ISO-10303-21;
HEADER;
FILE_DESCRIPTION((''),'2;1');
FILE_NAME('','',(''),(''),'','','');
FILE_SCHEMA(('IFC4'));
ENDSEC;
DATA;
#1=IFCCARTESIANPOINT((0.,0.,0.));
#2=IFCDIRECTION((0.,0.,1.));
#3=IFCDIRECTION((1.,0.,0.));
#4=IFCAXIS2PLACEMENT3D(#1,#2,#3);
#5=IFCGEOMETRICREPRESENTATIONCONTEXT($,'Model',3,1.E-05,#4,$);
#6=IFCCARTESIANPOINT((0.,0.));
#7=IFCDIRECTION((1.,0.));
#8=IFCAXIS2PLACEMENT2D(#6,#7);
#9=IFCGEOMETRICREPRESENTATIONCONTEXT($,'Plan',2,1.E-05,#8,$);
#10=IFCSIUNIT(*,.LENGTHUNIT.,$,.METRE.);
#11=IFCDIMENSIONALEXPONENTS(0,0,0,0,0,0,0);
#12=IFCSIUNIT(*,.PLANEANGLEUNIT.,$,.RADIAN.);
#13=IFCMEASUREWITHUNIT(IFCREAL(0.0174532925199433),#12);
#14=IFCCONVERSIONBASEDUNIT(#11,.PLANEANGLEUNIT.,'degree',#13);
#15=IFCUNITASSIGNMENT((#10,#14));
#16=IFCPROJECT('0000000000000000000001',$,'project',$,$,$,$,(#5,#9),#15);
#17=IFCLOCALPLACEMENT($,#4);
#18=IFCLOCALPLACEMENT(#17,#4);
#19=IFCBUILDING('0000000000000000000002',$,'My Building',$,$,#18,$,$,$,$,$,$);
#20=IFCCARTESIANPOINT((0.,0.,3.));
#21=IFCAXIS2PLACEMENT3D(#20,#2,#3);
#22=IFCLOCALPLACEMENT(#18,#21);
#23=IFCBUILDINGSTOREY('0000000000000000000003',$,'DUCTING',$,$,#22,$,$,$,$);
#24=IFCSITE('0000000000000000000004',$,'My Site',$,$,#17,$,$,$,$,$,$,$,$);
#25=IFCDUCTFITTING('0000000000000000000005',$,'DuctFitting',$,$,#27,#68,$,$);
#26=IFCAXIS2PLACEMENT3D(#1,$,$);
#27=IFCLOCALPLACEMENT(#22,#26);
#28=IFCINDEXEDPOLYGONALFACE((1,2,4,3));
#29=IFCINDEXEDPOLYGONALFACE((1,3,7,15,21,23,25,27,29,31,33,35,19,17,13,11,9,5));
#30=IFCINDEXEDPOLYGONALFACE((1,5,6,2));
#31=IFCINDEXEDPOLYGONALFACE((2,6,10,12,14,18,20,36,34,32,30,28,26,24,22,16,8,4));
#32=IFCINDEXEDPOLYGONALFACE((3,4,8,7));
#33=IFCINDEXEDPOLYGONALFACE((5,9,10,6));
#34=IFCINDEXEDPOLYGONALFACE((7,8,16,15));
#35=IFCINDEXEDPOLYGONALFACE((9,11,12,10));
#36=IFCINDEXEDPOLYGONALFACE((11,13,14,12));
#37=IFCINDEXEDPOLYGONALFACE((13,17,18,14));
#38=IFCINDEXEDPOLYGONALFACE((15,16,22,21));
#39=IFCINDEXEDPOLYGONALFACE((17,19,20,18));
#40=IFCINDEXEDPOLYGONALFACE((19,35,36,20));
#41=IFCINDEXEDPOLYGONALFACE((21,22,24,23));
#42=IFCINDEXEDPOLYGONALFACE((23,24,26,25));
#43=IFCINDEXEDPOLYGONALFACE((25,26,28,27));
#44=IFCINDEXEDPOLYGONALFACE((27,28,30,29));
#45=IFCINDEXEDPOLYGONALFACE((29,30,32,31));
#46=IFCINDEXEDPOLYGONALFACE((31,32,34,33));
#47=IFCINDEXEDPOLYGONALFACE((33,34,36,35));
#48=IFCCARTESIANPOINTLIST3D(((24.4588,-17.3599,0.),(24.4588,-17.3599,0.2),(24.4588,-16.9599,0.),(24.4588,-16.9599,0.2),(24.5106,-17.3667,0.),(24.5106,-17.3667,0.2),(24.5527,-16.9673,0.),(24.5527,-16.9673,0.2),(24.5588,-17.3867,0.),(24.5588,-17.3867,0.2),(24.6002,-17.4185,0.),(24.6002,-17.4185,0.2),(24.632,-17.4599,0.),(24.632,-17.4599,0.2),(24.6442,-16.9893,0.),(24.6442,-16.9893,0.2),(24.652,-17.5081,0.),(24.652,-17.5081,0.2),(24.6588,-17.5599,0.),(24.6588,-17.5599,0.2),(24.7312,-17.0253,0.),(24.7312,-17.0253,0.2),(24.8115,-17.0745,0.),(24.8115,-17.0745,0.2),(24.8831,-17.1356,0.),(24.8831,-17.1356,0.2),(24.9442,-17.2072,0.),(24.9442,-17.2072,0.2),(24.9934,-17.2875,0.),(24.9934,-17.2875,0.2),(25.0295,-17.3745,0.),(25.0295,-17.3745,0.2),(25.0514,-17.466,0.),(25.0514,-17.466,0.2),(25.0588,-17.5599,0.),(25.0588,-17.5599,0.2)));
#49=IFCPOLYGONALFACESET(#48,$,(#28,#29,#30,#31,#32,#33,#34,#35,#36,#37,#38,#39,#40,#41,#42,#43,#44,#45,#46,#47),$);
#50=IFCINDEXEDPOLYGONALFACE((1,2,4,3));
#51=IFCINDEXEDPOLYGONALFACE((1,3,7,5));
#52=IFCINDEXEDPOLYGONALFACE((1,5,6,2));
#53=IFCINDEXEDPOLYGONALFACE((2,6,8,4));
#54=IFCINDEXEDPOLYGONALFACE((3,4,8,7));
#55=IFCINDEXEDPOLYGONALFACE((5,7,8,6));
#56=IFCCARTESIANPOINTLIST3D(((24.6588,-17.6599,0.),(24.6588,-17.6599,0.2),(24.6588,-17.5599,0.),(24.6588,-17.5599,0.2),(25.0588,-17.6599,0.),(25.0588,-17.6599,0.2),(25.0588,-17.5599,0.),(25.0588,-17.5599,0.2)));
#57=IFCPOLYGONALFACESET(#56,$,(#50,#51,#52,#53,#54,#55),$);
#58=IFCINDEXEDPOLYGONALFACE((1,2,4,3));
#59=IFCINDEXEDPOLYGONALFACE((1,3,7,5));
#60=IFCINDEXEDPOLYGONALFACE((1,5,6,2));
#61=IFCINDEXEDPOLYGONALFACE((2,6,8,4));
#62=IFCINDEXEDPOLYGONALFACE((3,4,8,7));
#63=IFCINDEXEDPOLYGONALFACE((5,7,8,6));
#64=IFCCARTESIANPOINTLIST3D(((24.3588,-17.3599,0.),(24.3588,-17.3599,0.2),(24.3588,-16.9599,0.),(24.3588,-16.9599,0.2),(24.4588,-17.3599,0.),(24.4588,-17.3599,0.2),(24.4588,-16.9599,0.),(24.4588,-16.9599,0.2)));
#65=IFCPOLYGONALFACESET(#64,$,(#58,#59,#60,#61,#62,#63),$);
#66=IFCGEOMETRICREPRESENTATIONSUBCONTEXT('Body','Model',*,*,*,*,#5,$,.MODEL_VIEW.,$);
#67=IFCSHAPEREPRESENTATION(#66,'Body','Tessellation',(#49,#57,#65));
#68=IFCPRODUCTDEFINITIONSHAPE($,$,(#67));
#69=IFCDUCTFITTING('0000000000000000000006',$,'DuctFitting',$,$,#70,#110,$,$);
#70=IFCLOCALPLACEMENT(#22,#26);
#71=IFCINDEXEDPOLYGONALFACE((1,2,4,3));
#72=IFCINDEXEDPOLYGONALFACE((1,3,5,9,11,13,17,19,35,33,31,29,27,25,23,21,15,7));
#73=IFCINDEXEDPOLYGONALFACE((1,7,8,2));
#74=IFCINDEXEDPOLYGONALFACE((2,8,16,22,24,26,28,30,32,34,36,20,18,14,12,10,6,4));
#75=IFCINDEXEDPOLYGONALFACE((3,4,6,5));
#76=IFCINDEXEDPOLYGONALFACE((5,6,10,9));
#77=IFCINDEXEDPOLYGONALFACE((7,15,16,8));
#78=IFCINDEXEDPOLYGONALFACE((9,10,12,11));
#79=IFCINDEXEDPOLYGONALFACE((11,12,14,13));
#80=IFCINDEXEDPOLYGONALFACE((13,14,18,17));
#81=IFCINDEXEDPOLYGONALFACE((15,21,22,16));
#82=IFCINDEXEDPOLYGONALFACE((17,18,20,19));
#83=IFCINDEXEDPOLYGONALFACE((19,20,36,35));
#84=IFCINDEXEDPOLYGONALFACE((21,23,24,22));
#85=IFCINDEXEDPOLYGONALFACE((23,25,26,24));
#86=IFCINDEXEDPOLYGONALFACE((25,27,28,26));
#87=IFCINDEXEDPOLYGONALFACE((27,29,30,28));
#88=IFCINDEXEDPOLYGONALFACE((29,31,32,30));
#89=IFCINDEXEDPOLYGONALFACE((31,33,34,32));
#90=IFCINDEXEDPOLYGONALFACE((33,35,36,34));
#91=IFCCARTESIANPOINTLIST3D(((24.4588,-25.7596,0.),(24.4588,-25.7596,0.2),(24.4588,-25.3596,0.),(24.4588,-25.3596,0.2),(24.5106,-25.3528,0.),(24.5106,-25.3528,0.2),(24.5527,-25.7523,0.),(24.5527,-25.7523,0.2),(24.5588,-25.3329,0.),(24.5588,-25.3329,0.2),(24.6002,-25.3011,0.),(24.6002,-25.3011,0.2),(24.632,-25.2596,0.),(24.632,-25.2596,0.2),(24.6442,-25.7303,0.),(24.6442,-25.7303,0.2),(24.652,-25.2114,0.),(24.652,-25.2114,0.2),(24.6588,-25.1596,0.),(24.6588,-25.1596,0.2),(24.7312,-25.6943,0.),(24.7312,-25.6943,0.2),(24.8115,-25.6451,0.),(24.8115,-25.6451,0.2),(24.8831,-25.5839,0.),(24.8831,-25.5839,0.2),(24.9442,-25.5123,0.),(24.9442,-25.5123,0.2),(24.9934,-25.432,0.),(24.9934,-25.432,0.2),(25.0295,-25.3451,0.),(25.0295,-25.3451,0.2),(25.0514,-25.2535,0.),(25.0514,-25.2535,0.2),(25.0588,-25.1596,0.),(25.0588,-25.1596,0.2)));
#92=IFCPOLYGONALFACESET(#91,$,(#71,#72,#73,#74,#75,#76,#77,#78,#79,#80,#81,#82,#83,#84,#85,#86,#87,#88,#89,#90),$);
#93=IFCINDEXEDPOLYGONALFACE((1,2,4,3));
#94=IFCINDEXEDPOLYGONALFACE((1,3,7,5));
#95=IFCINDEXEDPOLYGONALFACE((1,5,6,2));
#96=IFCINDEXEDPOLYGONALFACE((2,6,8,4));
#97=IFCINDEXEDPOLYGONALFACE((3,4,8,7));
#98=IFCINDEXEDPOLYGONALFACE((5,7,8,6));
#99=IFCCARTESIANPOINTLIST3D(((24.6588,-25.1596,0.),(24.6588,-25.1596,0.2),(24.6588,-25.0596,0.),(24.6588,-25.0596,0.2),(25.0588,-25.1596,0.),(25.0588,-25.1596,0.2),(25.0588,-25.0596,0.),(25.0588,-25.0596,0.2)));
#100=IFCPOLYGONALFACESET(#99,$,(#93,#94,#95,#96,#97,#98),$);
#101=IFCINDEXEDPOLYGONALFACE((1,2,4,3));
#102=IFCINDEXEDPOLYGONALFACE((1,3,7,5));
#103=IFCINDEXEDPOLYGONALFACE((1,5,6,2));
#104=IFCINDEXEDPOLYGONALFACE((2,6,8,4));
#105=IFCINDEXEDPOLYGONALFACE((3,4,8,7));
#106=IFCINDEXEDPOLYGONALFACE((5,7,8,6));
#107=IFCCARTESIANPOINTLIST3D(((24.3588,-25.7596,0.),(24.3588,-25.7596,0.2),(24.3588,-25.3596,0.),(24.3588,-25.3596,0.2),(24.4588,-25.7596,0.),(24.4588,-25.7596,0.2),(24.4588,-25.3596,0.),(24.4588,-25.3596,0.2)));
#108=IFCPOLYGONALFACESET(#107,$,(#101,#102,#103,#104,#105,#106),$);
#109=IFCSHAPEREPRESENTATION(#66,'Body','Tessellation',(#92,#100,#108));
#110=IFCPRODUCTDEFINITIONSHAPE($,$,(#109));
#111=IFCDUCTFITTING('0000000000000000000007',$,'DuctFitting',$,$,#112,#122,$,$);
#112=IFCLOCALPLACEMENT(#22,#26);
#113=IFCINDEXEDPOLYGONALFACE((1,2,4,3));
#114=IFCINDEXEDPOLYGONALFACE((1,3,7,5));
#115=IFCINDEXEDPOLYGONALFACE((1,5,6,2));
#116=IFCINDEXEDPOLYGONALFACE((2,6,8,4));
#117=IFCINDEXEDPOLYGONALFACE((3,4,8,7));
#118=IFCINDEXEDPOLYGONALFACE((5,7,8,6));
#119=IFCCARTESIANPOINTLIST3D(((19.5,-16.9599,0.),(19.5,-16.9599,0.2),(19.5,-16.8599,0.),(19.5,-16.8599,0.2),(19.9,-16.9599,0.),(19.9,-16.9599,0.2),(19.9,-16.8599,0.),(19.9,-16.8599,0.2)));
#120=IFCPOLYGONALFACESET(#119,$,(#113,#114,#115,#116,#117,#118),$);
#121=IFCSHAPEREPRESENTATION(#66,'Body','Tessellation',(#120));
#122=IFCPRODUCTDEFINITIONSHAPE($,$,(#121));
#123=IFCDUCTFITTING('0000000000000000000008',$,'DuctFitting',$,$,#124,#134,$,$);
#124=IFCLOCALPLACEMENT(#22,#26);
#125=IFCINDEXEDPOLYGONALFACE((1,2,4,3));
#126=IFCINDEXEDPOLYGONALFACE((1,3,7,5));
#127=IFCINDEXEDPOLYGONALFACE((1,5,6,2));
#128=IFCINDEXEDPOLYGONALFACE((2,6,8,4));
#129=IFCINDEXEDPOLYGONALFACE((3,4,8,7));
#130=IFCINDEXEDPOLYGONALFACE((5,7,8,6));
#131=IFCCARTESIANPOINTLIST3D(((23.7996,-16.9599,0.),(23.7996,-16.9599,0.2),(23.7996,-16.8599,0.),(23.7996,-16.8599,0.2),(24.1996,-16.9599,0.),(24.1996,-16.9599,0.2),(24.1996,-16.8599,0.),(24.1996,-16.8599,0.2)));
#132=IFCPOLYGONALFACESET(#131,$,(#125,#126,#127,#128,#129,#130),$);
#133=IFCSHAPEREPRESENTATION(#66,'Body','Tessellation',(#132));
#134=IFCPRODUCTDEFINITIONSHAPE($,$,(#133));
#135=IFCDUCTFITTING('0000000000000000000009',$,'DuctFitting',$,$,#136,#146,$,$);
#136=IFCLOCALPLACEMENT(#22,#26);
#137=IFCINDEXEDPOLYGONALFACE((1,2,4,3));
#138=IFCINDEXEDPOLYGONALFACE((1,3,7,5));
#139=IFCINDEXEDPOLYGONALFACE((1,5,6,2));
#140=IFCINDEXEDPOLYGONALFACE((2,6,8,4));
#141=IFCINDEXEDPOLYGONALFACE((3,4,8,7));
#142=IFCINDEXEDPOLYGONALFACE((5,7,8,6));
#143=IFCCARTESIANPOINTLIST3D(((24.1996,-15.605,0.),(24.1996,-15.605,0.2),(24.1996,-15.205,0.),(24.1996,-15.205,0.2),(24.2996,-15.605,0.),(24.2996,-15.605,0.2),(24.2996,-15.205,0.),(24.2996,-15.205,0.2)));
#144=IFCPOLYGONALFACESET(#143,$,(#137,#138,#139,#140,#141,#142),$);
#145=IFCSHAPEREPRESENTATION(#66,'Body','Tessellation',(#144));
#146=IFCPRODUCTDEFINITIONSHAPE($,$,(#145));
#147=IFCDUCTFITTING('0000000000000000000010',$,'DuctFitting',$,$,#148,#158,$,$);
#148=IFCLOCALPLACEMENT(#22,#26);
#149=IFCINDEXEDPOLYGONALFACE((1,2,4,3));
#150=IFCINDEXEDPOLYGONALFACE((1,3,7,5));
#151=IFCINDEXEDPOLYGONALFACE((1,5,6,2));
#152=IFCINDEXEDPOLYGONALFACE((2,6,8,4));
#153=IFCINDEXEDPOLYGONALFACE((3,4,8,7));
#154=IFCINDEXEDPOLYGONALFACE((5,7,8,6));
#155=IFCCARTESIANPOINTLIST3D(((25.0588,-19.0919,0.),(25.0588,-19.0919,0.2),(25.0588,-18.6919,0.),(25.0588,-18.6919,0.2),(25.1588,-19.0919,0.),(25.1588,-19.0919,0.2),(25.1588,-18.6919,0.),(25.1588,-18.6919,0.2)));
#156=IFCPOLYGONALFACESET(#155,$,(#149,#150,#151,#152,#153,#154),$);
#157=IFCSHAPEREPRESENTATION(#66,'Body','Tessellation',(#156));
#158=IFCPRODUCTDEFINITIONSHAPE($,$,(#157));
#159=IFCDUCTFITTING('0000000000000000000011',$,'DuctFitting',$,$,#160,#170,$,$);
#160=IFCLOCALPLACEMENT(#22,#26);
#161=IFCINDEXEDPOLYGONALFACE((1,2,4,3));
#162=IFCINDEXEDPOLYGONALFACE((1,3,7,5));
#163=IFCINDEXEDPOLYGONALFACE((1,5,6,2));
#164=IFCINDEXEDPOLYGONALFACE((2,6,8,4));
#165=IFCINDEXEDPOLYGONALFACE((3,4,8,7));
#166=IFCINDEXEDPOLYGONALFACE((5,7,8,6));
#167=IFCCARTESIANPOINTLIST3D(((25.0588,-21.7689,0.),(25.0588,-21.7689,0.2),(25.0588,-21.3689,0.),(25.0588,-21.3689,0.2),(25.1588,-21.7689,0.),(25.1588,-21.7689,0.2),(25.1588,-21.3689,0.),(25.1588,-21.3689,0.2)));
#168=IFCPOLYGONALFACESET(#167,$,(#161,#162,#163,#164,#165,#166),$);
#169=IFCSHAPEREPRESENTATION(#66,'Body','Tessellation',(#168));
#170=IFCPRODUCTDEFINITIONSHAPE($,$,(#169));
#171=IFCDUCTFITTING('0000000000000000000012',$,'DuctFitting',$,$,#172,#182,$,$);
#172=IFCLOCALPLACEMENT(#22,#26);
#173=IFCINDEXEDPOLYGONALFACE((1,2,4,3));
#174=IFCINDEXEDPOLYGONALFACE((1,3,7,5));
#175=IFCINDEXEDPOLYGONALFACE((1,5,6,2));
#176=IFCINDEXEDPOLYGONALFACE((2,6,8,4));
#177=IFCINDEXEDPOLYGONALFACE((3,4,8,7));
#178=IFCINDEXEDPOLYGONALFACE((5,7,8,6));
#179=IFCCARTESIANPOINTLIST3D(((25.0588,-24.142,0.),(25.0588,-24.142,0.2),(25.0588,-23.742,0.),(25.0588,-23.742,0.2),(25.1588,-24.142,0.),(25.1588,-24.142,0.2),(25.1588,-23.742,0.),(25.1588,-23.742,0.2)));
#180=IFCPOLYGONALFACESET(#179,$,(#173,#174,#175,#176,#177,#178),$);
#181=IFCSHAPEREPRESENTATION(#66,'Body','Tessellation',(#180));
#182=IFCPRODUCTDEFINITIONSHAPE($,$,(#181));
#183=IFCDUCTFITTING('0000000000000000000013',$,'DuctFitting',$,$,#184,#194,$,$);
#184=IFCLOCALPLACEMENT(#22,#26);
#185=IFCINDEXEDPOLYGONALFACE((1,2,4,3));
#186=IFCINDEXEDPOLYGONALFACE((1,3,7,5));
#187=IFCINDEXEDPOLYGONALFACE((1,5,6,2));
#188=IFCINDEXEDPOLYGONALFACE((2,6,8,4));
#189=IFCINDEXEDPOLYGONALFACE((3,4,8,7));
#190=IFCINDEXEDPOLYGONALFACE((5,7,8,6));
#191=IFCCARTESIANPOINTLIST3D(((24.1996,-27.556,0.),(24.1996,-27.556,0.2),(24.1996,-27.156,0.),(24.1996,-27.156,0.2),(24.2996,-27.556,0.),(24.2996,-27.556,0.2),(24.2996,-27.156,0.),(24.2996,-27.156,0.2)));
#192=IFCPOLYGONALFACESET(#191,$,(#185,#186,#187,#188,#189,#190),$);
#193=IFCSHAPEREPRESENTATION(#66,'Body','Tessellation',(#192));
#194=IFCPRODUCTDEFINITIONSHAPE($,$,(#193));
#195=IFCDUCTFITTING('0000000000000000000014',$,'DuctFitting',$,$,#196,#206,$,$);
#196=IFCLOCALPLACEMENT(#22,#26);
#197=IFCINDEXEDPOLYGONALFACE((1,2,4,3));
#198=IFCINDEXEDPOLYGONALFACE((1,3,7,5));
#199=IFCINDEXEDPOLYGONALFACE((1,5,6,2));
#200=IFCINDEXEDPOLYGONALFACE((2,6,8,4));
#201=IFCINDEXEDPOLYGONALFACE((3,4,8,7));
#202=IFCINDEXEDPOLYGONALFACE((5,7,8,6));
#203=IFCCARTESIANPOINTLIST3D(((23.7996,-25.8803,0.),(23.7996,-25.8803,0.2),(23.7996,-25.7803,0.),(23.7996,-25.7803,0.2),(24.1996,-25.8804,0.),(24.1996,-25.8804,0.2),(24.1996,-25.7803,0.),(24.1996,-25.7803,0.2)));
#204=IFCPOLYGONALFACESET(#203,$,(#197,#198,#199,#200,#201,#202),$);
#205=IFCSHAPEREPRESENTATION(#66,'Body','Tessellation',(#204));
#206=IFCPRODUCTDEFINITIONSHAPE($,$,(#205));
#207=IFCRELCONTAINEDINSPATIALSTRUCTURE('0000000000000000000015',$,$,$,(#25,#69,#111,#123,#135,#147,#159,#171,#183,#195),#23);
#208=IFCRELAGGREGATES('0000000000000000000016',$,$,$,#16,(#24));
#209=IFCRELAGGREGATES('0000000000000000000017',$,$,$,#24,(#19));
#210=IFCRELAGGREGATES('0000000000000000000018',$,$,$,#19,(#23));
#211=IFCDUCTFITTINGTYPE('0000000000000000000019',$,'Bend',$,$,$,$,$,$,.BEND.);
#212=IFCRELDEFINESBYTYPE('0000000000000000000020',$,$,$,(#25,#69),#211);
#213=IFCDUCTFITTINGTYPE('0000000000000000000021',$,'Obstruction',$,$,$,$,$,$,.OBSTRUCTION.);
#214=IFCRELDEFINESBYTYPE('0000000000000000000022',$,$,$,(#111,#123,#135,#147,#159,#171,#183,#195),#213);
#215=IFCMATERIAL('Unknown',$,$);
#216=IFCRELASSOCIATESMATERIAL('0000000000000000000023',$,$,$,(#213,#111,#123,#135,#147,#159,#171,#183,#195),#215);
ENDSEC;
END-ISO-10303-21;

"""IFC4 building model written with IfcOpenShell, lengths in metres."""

from ifc_helpers import new_model, entity, si_unit, converted_unit, frame, origin_with_axes, origin_2d_with_axis, place, context, subcontext, project, spatial, line, arc, indexed_curve, rectangle, outline, extrude, source, transform, mapped, material, material_profile, profile_set, profile_usage, type_object, type_shapes, element, save


model = new_model("IFC4")

# Units and contexts
model_context = context("Model", 3, precision=1e-05, world=origin_with_axes())
plan_context = context("Plan", 2, precision=1e-05, world=origin_2d_with_axis())
body_context = subcontext(model_context, "Body", "Model", "MODEL_VIEW")
ifc_project = project(units=[si_unit("LENGTHUNIT", "METRE"), converted_unit("PLANEANGLEUNIT", "degree", entity("IfcReal", 0.0174532925199433), si_unit("PLANEANGLEUNIT", "RADIAN"), dimensions=[0, 0, 0, 0, 0, 0, 0])], contexts=[model_context, plan_context])

# Site, building, storey
site_placement = place(None, origin_with_axes())
site = spatial("IfcSite", under=ifc_project, at=site_placement, Name="My Site")
building_placement = place(site_placement, origin_with_axes())
building = spatial("IfcBuilding", under=site, at=building_placement, Name="My Building")
storey_placement = place(building_placement, frame((0.0, 0.0, 3.0), z_axis=(0.0, 0.0, 1.0), x_axis=(1.0, 0.0, 0.0)))
storey = spatial("IfcBuildingStorey", under=building, at=storey_placement, Name="DUCTING")

# Shared definitions
ifc_material = material(Name="Unknown")

# Duct fittings
duct_fitting_type_1 = type_object("IfcDuctFittingType", Name="Bend", PredefinedType="BEND")
shared_shape = source(origin_with_axes(), body_context, "Body", "SweptSolid", [
    extrude(outline(indexed_curve([(0.2, 0.0), (0.2586, 0.1414), (0.4, 0.2), (0.4, 0.6), (-0.0243, 0.4243), (-0.2, 0.0)], segments=[arc(1, 2, 3), line(3, 4), arc(4, 5, 6), line(6, 1)])), frame((0.0, -0.1, 0.1), z_axis=(0.0, -1.0, 0.0), x_axis=(1.0, 0.0, 0.0)), (0.0, 0.0, -1.0), 0.2),
    extrude(rectangle(XDim=0.4, YDim=0.2), origin_with_axes(), (0.0, 0.0, 1.0), 0.1),
    extrude(rectangle(XDim=0.4, YDim=0.2), frame((0.4, 0.0, 0.5), z_axis=(1.0, 0.0, 0.0), x_axis=(0.0, 0.0, 1.0)), (0.0, 0.0, 1.0), 0.1),
])
type_shapes(duct_fitting_type_1, [shared_shape])
for number, where, z_axis, x_axis, name in (
    (1, (24.8588, -17.6599, 0.1), (0.0, 1.0, 0.0), (-1.0, 0.0, 0.0), "DuctFitting"),
    (2, (24.8588, -25.0596, 0.1), (0.0, -1.0, 0.0), (-1.0, 0.0, 0.0), "DuctFitting"),
):
    element("IfcDuctFitting", number, at=place(storey_placement, frame(where, z_axis=z_axis, x_axis=x_axis)), inside=storey, type_object=duct_fitting_type_1, Name=name, context=body_context, shape_type="MappedRepresentation", body=[
        mapped(shared_shape, transform((0.0, 0.0, 0.0), x_axis=(1.0, 0.0, 0.0), y_axis=(0.0, 1.0, 0.0), z_axis=(0.0, 0.0, 1.0), scale=1.0)),
    ])
ifc_material_profile_1 = material_profile(ifc_material, rectangle(XDim=0.4, YDim=0.2))
ifc_profile_set_1 = profile_set([ifc_material_profile_1])
ifc_profile_usage_1 = profile_usage(ifc_profile_set_1, cardinal=5)
duct_fitting_type_2 = type_object("IfcDuctFittingType", Name="Obstruction", PredefinedType="OBSTRUCTION", material=ifc_profile_set_1)
duct_fitting_1_placement = place(storey_placement, frame((19.7, -16.8599, 0.1), z_axis=(0.0, -1.0, 0.0), x_axis=(1.0, 0.0, 0.0)))
element("IfcDuctFitting", 3, at=duct_fitting_1_placement, inside=storey, type_object=duct_fitting_type_2, material=ifc_profile_usage_1, Name="DuctFitting", context=body_context, shape_type="SweptSolid", body=[
    extrude(rectangle(XDim=0.4, YDim=0.2), origin_with_axes(), (0.0, 0.0, 1.0), 0.1),
])
ifc_profile_usage_2 = profile_usage(ifc_profile_set_1, cardinal=5)
duct_fitting_2_placement = place(storey_placement, frame((23.9996, -16.8599, 0.1), z_axis=(0.0, -1.0, 0.0), x_axis=(1.0, 0.0, 0.0)))
element("IfcDuctFitting", 4, at=duct_fitting_2_placement, inside=storey, type_object=duct_fitting_type_2, material=ifc_profile_usage_2, Name="DuctFitting", context=body_context, shape_type="SweptSolid", body=[
    extrude(rectangle(XDim=0.4, YDim=0.2), origin_with_axes(), (0.0, 0.0, 1.0), 0.1),
])
ifc_profile_usage_3 = profile_usage(ifc_profile_set_1, cardinal=5)
duct_fitting_3_placement = place(storey_placement, frame((24.2996, -15.405, 0.1), z_axis=(-1.0, 0.0, 0.0), x_axis=(0.0, -1.0, 0.0)))
element("IfcDuctFitting", 5, at=duct_fitting_3_placement, inside=storey, type_object=duct_fitting_type_2, material=ifc_profile_usage_3, Name="DuctFitting", context=body_context, shape_type="SweptSolid", body=[
    extrude(rectangle(XDim=0.4, YDim=0.2), origin_with_axes(), (0.0, 0.0, 1.0), 0.1),
])
ifc_profile_usage_4 = profile_usage(ifc_profile_set_1, cardinal=5)
duct_fitting_4_placement = place(storey_placement, frame((25.1588, -18.8919, 0.1), z_axis=(-1.0, 0.0, 0.0), x_axis=(0.0, -1.0, 0.0)))
element("IfcDuctFitting", 6, at=duct_fitting_4_placement, inside=storey, type_object=duct_fitting_type_2, material=ifc_profile_usage_4, Name="DuctFitting", context=body_context, shape_type="SweptSolid", body=[
    extrude(rectangle(XDim=0.4, YDim=0.2), origin_with_axes(), (0.0, 0.0, 1.0), 0.1),
])
ifc_profile_usage_5 = profile_usage(ifc_profile_set_1, cardinal=5)
duct_fitting_5_placement = place(storey_placement, frame((25.1588, -21.5689, 0.1), z_axis=(-1.0, 0.0, 0.0), x_axis=(0.0, -1.0, 0.0)))
element("IfcDuctFitting", 7, at=duct_fitting_5_placement, inside=storey, type_object=duct_fitting_type_2, material=ifc_profile_usage_5, Name="DuctFitting", context=body_context, shape_type="SweptSolid", body=[
    extrude(rectangle(XDim=0.4, YDim=0.2), origin_with_axes(), (0.0, 0.0, 1.0), 0.1),
])
ifc_profile_usage_6 = profile_usage(ifc_profile_set_1, cardinal=5)
duct_fitting_6_placement = place(storey_placement, frame((25.1588, -23.942, 0.1), z_axis=(-1.0, 0.0, 0.0), x_axis=(0.0, -1.0, 0.0)))
element("IfcDuctFitting", 8, at=duct_fitting_6_placement, inside=storey, type_object=duct_fitting_type_2, material=ifc_profile_usage_6, Name="DuctFitting", context=body_context, shape_type="SweptSolid", body=[
    extrude(rectangle(XDim=0.4, YDim=0.2), origin_with_axes(), (0.0, 0.0, 1.0), 0.1),
])
ifc_profile_usage_7 = profile_usage(ifc_profile_set_1, cardinal=5)
duct_fitting_7_placement = place(storey_placement, frame((24.2996, -27.356, 0.1), z_axis=(-1.0, 0.000001, 0.0), x_axis=(-0.000001, -1.0, 0.0)))
element("IfcDuctFitting", 9, at=duct_fitting_7_placement, inside=storey, type_object=duct_fitting_type_2, material=ifc_profile_usage_7, Name="DuctFitting", context=body_context, shape_type="SweptSolid", body=[
    extrude(rectangle(XDim=0.4, YDim=0.2), origin_with_axes(), (0.0, 0.0, 1.0), 0.1),
])
ifc_profile_usage_8 = profile_usage(ifc_profile_set_1, cardinal=5)
duct_fitting_8_placement = place(storey_placement, frame((23.9996, -25.8804, 0.1), z_axis=(0.000001, 1.0, 0.0), x_axis=(-1.0, 0.000001, 0.0)))
element("IfcDuctFitting", 10, at=duct_fitting_8_placement, inside=storey, type_object=duct_fitting_type_2, material=ifc_profile_usage_8, Name="DuctFitting", context=body_context, shape_type="SweptSolid", body=[
    extrude(rectangle(XDim=0.4, YDim=0.2), origin_with_axes(), (0.0, 0.0, 1.0), 0.1),
])

save(model, "model.ifc")
